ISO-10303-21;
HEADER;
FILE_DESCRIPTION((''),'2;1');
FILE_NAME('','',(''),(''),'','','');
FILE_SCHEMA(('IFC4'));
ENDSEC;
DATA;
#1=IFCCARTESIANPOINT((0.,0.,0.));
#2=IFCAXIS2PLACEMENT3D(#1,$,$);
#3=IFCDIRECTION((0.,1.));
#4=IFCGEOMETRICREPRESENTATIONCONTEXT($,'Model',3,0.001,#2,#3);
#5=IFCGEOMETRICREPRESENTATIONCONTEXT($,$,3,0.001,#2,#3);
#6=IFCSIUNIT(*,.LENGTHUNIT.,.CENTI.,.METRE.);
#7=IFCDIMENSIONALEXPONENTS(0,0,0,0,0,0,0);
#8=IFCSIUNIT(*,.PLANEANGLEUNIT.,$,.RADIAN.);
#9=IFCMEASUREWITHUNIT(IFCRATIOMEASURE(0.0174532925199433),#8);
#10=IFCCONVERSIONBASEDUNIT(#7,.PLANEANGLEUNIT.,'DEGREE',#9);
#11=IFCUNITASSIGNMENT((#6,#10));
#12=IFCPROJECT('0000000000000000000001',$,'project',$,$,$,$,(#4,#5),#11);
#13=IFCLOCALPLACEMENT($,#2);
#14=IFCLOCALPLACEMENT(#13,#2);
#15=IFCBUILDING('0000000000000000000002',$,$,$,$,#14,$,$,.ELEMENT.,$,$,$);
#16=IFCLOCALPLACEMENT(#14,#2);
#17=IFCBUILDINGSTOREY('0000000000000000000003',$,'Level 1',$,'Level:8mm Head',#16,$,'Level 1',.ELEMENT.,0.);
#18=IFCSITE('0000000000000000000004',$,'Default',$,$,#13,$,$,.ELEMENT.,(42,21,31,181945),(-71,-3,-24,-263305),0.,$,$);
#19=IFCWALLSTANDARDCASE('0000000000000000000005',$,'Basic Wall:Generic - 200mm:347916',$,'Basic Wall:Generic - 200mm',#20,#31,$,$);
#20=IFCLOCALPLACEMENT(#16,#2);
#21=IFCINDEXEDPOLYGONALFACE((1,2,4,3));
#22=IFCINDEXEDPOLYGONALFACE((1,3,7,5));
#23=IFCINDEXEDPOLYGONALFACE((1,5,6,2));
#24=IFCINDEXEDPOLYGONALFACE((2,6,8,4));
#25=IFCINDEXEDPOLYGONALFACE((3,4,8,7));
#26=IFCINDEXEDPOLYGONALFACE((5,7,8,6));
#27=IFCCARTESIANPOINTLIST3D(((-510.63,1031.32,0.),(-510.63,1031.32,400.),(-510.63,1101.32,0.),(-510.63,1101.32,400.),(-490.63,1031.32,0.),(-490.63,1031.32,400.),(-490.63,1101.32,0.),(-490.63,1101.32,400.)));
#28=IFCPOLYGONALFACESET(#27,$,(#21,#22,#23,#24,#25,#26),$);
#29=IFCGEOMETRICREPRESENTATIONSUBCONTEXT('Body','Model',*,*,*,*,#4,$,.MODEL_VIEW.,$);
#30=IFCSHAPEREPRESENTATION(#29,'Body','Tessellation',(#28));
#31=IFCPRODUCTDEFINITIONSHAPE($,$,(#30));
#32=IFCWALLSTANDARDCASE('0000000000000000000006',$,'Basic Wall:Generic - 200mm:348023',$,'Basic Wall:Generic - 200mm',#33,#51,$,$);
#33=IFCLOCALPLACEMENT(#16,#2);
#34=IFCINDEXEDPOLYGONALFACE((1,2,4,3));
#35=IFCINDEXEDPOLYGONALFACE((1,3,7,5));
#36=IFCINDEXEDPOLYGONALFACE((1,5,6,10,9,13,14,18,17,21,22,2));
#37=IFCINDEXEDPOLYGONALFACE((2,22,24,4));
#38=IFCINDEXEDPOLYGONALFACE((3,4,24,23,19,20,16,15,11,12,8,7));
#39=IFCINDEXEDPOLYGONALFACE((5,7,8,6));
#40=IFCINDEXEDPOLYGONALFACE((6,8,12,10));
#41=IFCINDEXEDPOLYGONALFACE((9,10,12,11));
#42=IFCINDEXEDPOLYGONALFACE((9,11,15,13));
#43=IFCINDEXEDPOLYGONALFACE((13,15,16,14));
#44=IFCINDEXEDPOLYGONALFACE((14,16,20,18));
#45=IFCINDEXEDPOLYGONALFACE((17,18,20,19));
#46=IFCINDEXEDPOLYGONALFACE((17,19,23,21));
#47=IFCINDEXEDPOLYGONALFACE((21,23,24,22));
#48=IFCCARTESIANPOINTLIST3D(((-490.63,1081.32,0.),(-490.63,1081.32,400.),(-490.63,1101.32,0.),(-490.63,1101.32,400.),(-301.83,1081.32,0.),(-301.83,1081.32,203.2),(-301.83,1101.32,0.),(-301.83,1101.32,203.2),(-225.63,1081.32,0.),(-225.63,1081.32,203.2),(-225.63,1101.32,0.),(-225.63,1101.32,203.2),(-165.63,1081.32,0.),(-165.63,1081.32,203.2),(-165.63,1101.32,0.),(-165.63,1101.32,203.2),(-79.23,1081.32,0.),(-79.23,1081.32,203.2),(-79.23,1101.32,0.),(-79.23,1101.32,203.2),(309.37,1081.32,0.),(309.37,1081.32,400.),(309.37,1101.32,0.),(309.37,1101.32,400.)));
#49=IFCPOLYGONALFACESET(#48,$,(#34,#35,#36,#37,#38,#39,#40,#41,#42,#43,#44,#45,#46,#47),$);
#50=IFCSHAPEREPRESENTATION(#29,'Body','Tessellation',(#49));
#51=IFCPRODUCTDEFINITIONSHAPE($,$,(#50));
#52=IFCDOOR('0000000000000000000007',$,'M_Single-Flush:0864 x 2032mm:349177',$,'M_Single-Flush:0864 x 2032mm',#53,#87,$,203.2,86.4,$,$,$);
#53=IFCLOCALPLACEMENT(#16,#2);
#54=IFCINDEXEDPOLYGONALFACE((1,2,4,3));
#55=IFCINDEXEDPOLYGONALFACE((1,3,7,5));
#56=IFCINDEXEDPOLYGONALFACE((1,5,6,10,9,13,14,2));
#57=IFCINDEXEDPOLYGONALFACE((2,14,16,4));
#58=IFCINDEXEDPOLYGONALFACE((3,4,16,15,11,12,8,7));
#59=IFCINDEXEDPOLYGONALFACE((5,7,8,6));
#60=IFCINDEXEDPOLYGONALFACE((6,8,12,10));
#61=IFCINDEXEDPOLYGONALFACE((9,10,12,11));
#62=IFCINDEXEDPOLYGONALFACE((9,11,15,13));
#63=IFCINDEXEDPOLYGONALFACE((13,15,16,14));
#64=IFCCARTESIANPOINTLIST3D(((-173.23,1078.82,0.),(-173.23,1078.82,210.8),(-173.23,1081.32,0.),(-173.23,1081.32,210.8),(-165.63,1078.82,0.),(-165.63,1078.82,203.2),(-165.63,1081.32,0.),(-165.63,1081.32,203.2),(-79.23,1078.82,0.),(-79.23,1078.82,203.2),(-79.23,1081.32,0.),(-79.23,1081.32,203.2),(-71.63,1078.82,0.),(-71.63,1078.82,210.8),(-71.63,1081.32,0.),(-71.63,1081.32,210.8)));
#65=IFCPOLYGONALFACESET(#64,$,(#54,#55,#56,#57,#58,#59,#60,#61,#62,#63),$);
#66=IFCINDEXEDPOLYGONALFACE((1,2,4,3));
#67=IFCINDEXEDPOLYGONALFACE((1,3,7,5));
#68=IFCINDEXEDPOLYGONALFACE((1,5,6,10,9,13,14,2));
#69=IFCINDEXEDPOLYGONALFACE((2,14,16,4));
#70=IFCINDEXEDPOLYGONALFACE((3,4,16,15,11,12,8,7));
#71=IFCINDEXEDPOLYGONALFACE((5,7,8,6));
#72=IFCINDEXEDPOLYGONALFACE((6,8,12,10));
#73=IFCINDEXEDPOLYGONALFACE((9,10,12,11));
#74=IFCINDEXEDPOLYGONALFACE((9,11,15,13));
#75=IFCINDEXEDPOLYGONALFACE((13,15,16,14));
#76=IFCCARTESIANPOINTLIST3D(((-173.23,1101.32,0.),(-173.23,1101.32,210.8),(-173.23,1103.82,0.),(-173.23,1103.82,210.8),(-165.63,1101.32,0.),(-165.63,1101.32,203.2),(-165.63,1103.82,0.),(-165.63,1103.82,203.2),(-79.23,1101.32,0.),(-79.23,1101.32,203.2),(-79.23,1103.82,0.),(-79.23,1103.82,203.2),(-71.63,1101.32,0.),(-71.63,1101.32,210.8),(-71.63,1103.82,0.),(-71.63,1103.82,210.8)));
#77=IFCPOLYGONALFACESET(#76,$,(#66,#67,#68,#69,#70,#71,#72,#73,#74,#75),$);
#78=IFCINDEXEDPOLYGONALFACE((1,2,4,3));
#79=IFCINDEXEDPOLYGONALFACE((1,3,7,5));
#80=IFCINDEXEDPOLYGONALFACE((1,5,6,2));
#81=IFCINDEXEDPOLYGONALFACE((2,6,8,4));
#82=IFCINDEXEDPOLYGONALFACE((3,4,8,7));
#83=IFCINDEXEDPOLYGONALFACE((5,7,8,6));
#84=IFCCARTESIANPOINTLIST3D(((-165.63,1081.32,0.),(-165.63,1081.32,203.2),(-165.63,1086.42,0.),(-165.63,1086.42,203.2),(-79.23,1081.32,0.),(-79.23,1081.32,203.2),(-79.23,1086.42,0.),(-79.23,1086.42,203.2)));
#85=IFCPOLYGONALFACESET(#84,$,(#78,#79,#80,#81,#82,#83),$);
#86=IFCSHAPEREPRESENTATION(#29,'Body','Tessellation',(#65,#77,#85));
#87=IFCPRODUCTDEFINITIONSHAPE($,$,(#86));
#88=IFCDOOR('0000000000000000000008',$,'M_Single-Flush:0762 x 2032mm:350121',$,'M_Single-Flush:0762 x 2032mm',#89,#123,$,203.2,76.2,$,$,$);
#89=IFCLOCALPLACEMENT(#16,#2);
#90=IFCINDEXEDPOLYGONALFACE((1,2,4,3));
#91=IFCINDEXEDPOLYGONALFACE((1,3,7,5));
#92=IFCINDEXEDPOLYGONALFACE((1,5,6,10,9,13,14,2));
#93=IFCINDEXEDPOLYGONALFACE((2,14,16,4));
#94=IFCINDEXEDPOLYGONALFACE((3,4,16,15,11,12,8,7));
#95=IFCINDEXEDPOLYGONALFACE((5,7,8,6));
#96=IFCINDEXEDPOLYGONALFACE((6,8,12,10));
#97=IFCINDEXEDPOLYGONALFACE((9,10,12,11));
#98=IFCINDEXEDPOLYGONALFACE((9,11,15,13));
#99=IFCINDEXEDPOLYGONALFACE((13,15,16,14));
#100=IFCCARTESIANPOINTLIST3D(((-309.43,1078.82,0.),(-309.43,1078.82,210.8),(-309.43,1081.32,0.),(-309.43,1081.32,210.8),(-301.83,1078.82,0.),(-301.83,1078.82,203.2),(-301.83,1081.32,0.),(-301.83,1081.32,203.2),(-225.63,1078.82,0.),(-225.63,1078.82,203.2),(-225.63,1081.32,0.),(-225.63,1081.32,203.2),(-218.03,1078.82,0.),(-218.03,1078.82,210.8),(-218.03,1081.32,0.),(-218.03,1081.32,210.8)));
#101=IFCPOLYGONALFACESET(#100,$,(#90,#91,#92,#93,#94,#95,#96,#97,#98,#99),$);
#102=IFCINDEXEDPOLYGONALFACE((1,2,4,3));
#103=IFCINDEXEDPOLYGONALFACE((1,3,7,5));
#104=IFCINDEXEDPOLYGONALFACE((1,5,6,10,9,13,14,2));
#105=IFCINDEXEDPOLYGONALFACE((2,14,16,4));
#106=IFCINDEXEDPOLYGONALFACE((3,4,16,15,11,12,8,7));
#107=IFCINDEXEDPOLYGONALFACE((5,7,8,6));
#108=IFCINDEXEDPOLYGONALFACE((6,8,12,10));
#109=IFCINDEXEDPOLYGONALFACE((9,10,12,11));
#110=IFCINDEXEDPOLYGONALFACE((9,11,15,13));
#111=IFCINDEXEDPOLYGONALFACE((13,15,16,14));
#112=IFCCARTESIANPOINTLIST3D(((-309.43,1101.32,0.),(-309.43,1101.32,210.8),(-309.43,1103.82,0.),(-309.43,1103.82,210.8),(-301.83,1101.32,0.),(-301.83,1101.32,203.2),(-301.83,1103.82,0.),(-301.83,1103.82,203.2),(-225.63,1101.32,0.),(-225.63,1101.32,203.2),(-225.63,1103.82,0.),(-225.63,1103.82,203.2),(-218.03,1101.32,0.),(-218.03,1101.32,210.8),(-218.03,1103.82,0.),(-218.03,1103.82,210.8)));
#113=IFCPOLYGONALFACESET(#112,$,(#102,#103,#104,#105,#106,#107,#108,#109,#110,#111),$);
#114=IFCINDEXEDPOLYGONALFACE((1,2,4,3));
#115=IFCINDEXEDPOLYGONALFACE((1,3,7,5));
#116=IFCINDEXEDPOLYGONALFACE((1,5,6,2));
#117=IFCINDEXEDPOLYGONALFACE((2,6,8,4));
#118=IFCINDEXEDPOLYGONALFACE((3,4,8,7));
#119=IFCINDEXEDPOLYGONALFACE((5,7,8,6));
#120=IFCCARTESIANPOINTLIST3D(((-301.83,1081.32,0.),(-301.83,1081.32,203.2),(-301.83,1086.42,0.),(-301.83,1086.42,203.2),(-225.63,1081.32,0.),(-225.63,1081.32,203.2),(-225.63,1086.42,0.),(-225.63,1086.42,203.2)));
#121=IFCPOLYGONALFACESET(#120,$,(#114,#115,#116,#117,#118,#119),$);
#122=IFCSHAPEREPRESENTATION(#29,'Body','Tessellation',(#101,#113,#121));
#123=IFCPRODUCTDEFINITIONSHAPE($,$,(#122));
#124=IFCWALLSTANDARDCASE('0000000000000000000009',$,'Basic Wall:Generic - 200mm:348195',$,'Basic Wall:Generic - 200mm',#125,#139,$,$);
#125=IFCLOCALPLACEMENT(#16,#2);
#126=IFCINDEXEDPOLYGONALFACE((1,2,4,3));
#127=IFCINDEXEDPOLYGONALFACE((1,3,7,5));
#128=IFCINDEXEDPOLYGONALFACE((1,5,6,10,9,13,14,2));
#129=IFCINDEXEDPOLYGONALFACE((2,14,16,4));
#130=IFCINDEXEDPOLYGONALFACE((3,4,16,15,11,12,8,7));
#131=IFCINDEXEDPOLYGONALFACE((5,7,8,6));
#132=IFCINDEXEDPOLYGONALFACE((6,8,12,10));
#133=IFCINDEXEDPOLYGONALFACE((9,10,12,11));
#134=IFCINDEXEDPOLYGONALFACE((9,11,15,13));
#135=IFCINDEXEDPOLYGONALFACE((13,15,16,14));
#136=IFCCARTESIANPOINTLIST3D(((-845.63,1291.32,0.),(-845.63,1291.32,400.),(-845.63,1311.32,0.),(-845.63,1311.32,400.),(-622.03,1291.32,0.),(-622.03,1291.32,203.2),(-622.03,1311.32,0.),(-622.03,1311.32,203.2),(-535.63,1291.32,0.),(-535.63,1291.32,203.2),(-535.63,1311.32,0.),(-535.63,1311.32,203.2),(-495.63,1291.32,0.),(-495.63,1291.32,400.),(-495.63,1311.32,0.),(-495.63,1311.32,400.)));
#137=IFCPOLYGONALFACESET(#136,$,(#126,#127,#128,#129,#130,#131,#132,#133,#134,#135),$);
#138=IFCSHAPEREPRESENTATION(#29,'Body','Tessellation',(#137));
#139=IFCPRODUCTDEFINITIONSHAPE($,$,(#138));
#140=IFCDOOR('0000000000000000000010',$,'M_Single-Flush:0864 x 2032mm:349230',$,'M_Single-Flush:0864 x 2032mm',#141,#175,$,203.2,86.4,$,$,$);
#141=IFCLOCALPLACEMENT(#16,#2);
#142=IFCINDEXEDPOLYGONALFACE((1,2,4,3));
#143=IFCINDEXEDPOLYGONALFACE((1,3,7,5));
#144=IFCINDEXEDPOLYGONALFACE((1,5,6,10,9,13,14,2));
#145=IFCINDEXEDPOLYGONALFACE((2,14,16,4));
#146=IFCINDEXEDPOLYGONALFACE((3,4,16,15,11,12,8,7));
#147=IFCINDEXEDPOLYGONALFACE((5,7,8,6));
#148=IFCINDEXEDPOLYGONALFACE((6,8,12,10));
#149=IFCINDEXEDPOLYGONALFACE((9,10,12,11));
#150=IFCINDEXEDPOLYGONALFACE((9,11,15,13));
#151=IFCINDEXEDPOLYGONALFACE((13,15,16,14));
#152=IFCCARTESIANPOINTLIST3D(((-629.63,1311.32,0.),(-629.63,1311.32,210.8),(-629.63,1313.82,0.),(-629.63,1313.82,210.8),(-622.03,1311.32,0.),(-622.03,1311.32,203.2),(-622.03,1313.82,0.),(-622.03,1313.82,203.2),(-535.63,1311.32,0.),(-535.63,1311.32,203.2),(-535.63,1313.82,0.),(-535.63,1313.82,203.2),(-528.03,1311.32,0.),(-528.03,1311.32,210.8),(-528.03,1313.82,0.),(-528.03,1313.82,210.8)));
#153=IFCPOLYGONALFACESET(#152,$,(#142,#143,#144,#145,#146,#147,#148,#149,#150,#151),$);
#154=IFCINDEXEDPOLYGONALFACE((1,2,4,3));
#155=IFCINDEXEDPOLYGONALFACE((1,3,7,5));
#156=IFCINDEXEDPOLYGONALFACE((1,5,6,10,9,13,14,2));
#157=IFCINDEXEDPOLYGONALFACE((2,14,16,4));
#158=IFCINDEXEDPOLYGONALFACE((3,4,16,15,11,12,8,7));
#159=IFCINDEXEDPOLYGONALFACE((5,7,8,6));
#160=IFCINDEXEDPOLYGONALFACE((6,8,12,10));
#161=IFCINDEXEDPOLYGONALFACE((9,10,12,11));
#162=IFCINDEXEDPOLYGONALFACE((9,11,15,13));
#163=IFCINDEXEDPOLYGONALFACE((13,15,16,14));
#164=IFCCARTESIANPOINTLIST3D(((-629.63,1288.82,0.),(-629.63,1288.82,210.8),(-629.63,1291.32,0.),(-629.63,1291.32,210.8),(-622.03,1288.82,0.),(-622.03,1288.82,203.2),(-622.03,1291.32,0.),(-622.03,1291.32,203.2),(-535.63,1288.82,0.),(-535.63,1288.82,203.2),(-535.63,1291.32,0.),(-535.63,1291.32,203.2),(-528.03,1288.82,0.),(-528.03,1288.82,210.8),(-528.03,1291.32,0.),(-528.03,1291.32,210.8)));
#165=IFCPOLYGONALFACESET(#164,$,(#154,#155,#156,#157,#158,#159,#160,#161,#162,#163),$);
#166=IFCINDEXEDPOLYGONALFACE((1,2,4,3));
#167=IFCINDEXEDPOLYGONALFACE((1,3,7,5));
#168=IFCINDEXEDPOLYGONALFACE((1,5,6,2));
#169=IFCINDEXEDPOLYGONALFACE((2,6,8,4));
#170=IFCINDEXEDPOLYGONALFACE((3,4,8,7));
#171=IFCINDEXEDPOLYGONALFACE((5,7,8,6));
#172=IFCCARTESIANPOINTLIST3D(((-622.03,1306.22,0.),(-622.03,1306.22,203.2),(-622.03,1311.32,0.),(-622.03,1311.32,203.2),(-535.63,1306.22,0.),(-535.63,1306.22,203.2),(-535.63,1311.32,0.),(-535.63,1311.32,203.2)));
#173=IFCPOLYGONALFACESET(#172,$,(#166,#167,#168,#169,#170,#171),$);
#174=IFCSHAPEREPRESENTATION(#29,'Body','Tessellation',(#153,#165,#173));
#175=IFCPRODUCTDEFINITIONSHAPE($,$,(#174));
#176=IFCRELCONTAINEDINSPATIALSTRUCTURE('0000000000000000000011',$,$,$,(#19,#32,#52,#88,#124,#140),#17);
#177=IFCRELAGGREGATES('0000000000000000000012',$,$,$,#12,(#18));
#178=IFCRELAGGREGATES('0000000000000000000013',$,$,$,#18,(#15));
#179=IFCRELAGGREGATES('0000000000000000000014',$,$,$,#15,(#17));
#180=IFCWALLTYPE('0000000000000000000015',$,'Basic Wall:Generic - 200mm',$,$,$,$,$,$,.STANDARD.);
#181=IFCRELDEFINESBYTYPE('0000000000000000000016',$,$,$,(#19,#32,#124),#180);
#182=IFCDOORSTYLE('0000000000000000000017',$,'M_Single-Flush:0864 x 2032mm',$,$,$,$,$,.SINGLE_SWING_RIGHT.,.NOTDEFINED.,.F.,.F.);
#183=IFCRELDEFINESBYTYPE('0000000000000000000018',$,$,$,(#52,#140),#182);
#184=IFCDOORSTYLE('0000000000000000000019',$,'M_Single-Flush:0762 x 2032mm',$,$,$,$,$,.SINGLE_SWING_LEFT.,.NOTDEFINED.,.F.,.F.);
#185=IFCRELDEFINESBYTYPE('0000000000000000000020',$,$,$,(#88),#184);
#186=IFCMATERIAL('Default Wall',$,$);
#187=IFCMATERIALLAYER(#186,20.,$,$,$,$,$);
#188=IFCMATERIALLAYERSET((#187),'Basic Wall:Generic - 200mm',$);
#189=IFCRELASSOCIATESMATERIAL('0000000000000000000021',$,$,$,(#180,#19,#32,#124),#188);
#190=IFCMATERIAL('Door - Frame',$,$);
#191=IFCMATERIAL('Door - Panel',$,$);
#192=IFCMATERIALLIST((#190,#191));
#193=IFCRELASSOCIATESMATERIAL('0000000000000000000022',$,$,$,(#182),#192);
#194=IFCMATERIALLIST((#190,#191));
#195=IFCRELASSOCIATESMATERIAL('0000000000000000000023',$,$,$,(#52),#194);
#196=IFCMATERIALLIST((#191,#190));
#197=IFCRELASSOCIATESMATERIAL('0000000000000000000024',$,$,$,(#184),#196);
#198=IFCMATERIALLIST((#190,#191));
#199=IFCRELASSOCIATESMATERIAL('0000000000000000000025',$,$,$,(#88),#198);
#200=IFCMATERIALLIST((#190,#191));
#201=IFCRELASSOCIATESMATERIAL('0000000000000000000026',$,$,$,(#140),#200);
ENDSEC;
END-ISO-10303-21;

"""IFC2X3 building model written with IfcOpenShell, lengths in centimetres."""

from ifc_helpers import new_model, entity, si_unit, converted_unit, direction, frame, frame_2d, origin, place, context, subcontext, project, spatial, polyline, rectangle, outline, extrude, source, transform, mapped, material, material_list, layer, layer_set, layer_usage, type_object, type_shapes, element, fill, save


model = new_model("IFC2X3")

# Units and contexts
model_context = context("Model", 3, precision=0.001, world=origin(), true_north=direction((0.0, 1.0)))
context_of_model = context(None, 3, precision=0.001, world=origin(), true_north=direction((0.0, 1.0)))
body_context = subcontext(model_context, "Body", "Model", "MODEL_VIEW")
ifc_project = project(units=[si_unit("LENGTHUNIT", "METRE", prefix="CENTI"), converted_unit("PLANEANGLEUNIT", "DEGREE", entity("IfcRatioMeasure", 0.0174532925199433), si_unit("PLANEANGLEUNIT", "RADIAN"), dimensions=[0, 0, 0, 0, 0, 0, 0])], contexts=[model_context, context_of_model])

# Site, building, storey
site_placement = place(None, origin())
site = spatial("IfcSite", under=ifc_project, at=site_placement, Name="Default", CompositionType="ELEMENT", RefLatitude=(42, 21, 31, 181945), RefLongitude=(-71, -3, -24, -263305), RefElevation=0.0)
building_placement = place(site_placement, origin())
building = spatial("IfcBuilding", under=site, at=building_placement, CompositionType="ELEMENT")
storey_placement = place(building_placement, origin())
storey = spatial("IfcBuildingStorey", under=building, at=storey_placement, Name="Level 1", ObjectType="Level:8mm Head", LongName="Level 1", CompositionType="ELEMENT", Elevation=0.0)

# Shared definitions
ifc_material_1 = material(Name="Default Wall")

# Wall
ifc_layer_1 = layer(ifc_material_1, 20.0)
ifc_layer_set_1 = layer_set([ifc_layer_1], Name="Basic Wall:Generic - 200mm")
ifc_layer_usage_1 = layer_usage(ifc_layer_set_1, "AXIS2", "NEGATIVE", 10.0)
wall_type_1 = type_object("IfcWallType", Name="Basic Wall:Generic - 200mm", PredefinedType="STANDARD", material=ifc_layer_set_1)
wall_1_placement = place(storey_placement, frame((-500.63, 1031.32, 0.0), z_axis=(0.0, 0.0, 1.0), x_axis=(0.0, 1.0, 0.0)))
element("IfcWallStandardCase", 1, at=wall_1_placement, inside=storey, type_object=wall_type_1, material=ifc_layer_usage_1, Name="Basic Wall:Generic - 200mm:347916", ObjectType="Basic Wall:Generic - 200mm", context=body_context, shape_type="SweptSolid", body=[
    extrude(rectangle(XDim=70.0, YDim=20.0, at=frame_2d((35.0, 0.0), x_axis=(-1.0, 0.0))), origin(), (0.0, 0.0, 1.0), 400.0),
])

# Wall, openings, doors
ifc_layer_usage_2 = layer_usage(ifc_layer_set_1, "AXIS2", "NEGATIVE", 10.0)
wall_2_placement = place(storey_placement, frame((-490.63, 1091.32, 0.0)))
wall_2 = element("IfcWallStandardCase", 2, at=wall_2_placement, inside=storey, type_object=wall_type_1, material=ifc_layer_usage_2, Name="Basic Wall:Generic - 200mm:348023", ObjectType="Basic Wall:Generic - 200mm", context=body_context, shape_type="SweptSolid", body=[
    extrude(rectangle(XDim=800.0, YDim=20.0, at=frame_2d((400.0, 0.0), x_axis=(-1.0, 0.0))), origin(), (0.0, 0.0, 1.0), 400.0),
])
opening_1_placement = place(wall_2_placement, frame((411.4, 10.0, 0.0)))
opening_1 = element("IfcOpeningElement", 3, at=opening_1_placement, cuts=wall_2, ObjectType="Opening", context=body_context, shape_type="SweptSolid", body=[
    extrude(rectangle(XDim=86.4, YDim=203.2, at=frame_2d((101.6, 43.2), x_axis=(0.0, 1.0))), frame((0.0, 0.0, 0.0), z_axis=(0.0, -1.0, 0.0), x_axis=(0.0, 0.0, 1.0)), (0.0, 0.0, 1.0), 20.0),
])
opening_2_placement = place(wall_2_placement, frame((265.0, 10.0, 0.0)))
opening_2 = element("IfcOpeningElement", 4, at=opening_2_placement, cuts=wall_2, ObjectType="Opening", context=body_context, shape_type="SweptSolid", body=[
    extrude(rectangle(XDim=76.2, YDim=203.2, at=frame_2d((101.6, 38.1), x_axis=(0.0, -1.0))), frame((0.0, 0.0, 0.0), z_axis=(0.0, -1.0, 0.0), x_axis=(0.0, 0.0, 1.0)), (0.0, 0.0, 1.0), 20.0),
])
ifc_material_2 = material(Name="Door - Frame")
ifc_material_3 = material(Name="Door - Panel")
ifc_material_list_1 = material_list([ifc_material_2, ifc_material_3])
ifc_material_list_2 = material_list([ifc_material_2, ifc_material_3])
door_style_1 = type_object("IfcDoorStyle", Name="M_Single-Flush:0864 x 2032mm", ConstructionType="NOTDEFINED", OperationType="SINGLE_SWING_RIGHT", ParameterTakesPrecedence=False, Sizeable=False, material=ifc_material_list_2)
shared_shape_1 = source(origin(), body_context, "Body", "SweptSolid", [
    extrude(outline(polyline([(-50.8, -107.3), (50.8, -107.3), (50.8, 103.5), (43.2, 103.5), (43.2, -99.7), (-43.2, -99.7), (-43.2, 103.5), (-50.8, 103.5), (-50.8, -107.3)])), frame((43.2, 20.0, 103.5), z_axis=(0.0, 1.0, 0.0), x_axis=(1.0, 0.0, 0.0)), (0.0, 0.0, 1.0), 2.5),
    extrude(outline(polyline([(-107.3, -50.8), (103.5, -50.8), (103.5, -43.2), (-99.7, -43.2), (-99.7, 43.2), (103.5, 43.2), (103.5, 50.8), (-107.3, 50.8), (-107.3, -50.8)])), frame((43.2, -2.5, 103.5), z_axis=(0.0, 1.0, 0.0), x_axis=(0.0, 0.0, -1.0)), (0.0, 0.0, 1.0), 2.5),
    extrude(rectangle(XDim=5.1, YDim=86.4, at=frame_2d((0.0, 0.0), x_axis=(1.0, 0.0))), frame((43.2, 17.45, 0.0), z_axis=(0.0, 0.0, 1.0), x_axis=(0.0, 1.0, 0.0)), (0.0, 0.0, 1.0), 203.2),
])
type_shapes(door_style_1, [shared_shape_1])
door_1_placement = place(opening_1_placement, frame((0.0, 0.0, 0.0), z_axis=(0.0, 0.0, 1.0), x_axis=(-1.0, 0.0, 0.0)))
door_1 = element("IfcDoor", 5, at=door_1_placement, inside=storey, type_object=door_style_1, material=ifc_material_list_1, Name="M_Single-Flush:0864 x 2032mm:349177", ObjectType="M_Single-Flush:0864 x 2032mm", OverallHeight=203.2, OverallWidth=86.4, context=body_context, shape_type="MappedRepresentation", body=[
    mapped(shared_shape_1, transform((0.0, 0.0, 0.0), scale=1.0)),
])
fill(opening_1, door_1)
ifc_material_list_3 = material_list([ifc_material_2, ifc_material_3])
ifc_material_list_4 = material_list([ifc_material_3, ifc_material_2])
door_style_2 = type_object("IfcDoorStyle", Name="M_Single-Flush:0762 x 2032mm", ConstructionType="NOTDEFINED", OperationType="SINGLE_SWING_LEFT", ParameterTakesPrecedence=False, Sizeable=False, material=ifc_material_list_4)
shared_shape_2 = source(origin(), body_context, "Body", "SweptSolid", [
    extrude(outline(polyline([(-45.7, -107.3), (45.7, -107.3), (45.7, 103.5), (38.1, 103.5), (38.1, -99.7), (-38.1, -99.7), (-38.1, 103.5), (-45.7, 103.5), (-45.7, -107.3)])), frame((38.1, 22.5, 103.5), z_axis=(0.0, -1.0, 0.0), x_axis=(-1.0, 0.0, 0.0)), (0.0, 0.0, 1.0), 2.5),
    extrude(outline(polyline([(-107.3, -45.7), (103.5, -45.7), (103.5, -38.1), (-99.7, -38.1), (-99.7, 38.1), (103.5, 38.1), (103.5, 45.7), (-107.3, 45.7), (-107.3, -45.7)])), frame((38.1, 0.0, 103.5), z_axis=(0.0, -1.0, 0.0), x_axis=(0.0, 0.0, -1.0)), (0.0, 0.0, 1.0), 2.5),
    extrude(rectangle(XDim=76.2, YDim=5.1, at=frame_2d((0.0, 0.0), x_axis=(1.0, 0.0))), frame((38.1, 17.45, 0.0)), (0.0, 0.0, 1.0), 203.2),
])
type_shapes(door_style_2, [shared_shape_2])
door_2_placement = place(opening_2_placement, frame((0.0, 0.0, 0.0), z_axis=(0.0, 0.0, 1.0), x_axis=(-1.0, 0.0, 0.0)))
door_2 = element("IfcDoor", 6, at=door_2_placement, inside=storey, type_object=door_style_2, material=ifc_material_list_3, Name="M_Single-Flush:0762 x 2032mm:350121", ObjectType="M_Single-Flush:0762 x 2032mm", OverallHeight=203.2, OverallWidth=76.2, context=body_context, shape_type="MappedRepresentation", body=[
    mapped(shared_shape_2, transform((0.0, 0.0, 0.0), scale=1.0)),
])
fill(opening_2, door_2)

# Wall, opening, door
ifc_layer_usage_3 = layer_usage(ifc_layer_set_1, "AXIS2", "NEGATIVE", 10.0)
wall_3_placement = place(storey_placement, frame((-845.63, 1301.32, 0.0)))
wall_3 = element("IfcWallStandardCase", 7, at=wall_3_placement, inside=storey, type_object=wall_type_1, material=ifc_layer_usage_3, Name="Basic Wall:Generic - 200mm:348195", ObjectType="Basic Wall:Generic - 200mm", context=body_context, shape_type="SweptSolid", body=[
    extrude(rectangle(XDim=350.0, YDim=20.0, at=frame_2d((175.0, 0.0), x_axis=(-1.0, 0.0))), origin(), (0.0, 0.0, 1.0), 400.0),
])
opening_3_placement = place(wall_3_placement, frame((223.6, -10.0, 0.0)))
opening_3 = element("IfcOpeningElement", 8, at=opening_3_placement, cuts=wall_3, ObjectType="Opening", context=body_context, shape_type="SweptSolid", body=[
    extrude(rectangle(XDim=86.4, YDim=203.2, at=frame_2d((101.6, 43.2), x_axis=(0.0, 1.0))), frame((0.0, 0.0, 0.0), z_axis=(0.0, 1.0, 0.0), x_axis=(0.0, 0.0, 1.0)), (0.0, 0.0, 1.0), 20.0),
])
ifc_material_list_5 = material_list([ifc_material_2, ifc_material_3])
door_3_placement = place(opening_3_placement, origin())
door_3 = element("IfcDoor", 9, at=door_3_placement, inside=storey, type_object=door_style_1, material=ifc_material_list_5, Name="M_Single-Flush:0864 x 2032mm:349230", ObjectType="M_Single-Flush:0864 x 2032mm", OverallHeight=203.2, OverallWidth=86.4, context=body_context, shape_type="MappedRepresentation", body=[
    mapped(shared_shape_1, transform((0.0, 0.0, 0.0), scale=1.0)),
])
fill(opening_3, door_3)

save(model, "model.ifc")
